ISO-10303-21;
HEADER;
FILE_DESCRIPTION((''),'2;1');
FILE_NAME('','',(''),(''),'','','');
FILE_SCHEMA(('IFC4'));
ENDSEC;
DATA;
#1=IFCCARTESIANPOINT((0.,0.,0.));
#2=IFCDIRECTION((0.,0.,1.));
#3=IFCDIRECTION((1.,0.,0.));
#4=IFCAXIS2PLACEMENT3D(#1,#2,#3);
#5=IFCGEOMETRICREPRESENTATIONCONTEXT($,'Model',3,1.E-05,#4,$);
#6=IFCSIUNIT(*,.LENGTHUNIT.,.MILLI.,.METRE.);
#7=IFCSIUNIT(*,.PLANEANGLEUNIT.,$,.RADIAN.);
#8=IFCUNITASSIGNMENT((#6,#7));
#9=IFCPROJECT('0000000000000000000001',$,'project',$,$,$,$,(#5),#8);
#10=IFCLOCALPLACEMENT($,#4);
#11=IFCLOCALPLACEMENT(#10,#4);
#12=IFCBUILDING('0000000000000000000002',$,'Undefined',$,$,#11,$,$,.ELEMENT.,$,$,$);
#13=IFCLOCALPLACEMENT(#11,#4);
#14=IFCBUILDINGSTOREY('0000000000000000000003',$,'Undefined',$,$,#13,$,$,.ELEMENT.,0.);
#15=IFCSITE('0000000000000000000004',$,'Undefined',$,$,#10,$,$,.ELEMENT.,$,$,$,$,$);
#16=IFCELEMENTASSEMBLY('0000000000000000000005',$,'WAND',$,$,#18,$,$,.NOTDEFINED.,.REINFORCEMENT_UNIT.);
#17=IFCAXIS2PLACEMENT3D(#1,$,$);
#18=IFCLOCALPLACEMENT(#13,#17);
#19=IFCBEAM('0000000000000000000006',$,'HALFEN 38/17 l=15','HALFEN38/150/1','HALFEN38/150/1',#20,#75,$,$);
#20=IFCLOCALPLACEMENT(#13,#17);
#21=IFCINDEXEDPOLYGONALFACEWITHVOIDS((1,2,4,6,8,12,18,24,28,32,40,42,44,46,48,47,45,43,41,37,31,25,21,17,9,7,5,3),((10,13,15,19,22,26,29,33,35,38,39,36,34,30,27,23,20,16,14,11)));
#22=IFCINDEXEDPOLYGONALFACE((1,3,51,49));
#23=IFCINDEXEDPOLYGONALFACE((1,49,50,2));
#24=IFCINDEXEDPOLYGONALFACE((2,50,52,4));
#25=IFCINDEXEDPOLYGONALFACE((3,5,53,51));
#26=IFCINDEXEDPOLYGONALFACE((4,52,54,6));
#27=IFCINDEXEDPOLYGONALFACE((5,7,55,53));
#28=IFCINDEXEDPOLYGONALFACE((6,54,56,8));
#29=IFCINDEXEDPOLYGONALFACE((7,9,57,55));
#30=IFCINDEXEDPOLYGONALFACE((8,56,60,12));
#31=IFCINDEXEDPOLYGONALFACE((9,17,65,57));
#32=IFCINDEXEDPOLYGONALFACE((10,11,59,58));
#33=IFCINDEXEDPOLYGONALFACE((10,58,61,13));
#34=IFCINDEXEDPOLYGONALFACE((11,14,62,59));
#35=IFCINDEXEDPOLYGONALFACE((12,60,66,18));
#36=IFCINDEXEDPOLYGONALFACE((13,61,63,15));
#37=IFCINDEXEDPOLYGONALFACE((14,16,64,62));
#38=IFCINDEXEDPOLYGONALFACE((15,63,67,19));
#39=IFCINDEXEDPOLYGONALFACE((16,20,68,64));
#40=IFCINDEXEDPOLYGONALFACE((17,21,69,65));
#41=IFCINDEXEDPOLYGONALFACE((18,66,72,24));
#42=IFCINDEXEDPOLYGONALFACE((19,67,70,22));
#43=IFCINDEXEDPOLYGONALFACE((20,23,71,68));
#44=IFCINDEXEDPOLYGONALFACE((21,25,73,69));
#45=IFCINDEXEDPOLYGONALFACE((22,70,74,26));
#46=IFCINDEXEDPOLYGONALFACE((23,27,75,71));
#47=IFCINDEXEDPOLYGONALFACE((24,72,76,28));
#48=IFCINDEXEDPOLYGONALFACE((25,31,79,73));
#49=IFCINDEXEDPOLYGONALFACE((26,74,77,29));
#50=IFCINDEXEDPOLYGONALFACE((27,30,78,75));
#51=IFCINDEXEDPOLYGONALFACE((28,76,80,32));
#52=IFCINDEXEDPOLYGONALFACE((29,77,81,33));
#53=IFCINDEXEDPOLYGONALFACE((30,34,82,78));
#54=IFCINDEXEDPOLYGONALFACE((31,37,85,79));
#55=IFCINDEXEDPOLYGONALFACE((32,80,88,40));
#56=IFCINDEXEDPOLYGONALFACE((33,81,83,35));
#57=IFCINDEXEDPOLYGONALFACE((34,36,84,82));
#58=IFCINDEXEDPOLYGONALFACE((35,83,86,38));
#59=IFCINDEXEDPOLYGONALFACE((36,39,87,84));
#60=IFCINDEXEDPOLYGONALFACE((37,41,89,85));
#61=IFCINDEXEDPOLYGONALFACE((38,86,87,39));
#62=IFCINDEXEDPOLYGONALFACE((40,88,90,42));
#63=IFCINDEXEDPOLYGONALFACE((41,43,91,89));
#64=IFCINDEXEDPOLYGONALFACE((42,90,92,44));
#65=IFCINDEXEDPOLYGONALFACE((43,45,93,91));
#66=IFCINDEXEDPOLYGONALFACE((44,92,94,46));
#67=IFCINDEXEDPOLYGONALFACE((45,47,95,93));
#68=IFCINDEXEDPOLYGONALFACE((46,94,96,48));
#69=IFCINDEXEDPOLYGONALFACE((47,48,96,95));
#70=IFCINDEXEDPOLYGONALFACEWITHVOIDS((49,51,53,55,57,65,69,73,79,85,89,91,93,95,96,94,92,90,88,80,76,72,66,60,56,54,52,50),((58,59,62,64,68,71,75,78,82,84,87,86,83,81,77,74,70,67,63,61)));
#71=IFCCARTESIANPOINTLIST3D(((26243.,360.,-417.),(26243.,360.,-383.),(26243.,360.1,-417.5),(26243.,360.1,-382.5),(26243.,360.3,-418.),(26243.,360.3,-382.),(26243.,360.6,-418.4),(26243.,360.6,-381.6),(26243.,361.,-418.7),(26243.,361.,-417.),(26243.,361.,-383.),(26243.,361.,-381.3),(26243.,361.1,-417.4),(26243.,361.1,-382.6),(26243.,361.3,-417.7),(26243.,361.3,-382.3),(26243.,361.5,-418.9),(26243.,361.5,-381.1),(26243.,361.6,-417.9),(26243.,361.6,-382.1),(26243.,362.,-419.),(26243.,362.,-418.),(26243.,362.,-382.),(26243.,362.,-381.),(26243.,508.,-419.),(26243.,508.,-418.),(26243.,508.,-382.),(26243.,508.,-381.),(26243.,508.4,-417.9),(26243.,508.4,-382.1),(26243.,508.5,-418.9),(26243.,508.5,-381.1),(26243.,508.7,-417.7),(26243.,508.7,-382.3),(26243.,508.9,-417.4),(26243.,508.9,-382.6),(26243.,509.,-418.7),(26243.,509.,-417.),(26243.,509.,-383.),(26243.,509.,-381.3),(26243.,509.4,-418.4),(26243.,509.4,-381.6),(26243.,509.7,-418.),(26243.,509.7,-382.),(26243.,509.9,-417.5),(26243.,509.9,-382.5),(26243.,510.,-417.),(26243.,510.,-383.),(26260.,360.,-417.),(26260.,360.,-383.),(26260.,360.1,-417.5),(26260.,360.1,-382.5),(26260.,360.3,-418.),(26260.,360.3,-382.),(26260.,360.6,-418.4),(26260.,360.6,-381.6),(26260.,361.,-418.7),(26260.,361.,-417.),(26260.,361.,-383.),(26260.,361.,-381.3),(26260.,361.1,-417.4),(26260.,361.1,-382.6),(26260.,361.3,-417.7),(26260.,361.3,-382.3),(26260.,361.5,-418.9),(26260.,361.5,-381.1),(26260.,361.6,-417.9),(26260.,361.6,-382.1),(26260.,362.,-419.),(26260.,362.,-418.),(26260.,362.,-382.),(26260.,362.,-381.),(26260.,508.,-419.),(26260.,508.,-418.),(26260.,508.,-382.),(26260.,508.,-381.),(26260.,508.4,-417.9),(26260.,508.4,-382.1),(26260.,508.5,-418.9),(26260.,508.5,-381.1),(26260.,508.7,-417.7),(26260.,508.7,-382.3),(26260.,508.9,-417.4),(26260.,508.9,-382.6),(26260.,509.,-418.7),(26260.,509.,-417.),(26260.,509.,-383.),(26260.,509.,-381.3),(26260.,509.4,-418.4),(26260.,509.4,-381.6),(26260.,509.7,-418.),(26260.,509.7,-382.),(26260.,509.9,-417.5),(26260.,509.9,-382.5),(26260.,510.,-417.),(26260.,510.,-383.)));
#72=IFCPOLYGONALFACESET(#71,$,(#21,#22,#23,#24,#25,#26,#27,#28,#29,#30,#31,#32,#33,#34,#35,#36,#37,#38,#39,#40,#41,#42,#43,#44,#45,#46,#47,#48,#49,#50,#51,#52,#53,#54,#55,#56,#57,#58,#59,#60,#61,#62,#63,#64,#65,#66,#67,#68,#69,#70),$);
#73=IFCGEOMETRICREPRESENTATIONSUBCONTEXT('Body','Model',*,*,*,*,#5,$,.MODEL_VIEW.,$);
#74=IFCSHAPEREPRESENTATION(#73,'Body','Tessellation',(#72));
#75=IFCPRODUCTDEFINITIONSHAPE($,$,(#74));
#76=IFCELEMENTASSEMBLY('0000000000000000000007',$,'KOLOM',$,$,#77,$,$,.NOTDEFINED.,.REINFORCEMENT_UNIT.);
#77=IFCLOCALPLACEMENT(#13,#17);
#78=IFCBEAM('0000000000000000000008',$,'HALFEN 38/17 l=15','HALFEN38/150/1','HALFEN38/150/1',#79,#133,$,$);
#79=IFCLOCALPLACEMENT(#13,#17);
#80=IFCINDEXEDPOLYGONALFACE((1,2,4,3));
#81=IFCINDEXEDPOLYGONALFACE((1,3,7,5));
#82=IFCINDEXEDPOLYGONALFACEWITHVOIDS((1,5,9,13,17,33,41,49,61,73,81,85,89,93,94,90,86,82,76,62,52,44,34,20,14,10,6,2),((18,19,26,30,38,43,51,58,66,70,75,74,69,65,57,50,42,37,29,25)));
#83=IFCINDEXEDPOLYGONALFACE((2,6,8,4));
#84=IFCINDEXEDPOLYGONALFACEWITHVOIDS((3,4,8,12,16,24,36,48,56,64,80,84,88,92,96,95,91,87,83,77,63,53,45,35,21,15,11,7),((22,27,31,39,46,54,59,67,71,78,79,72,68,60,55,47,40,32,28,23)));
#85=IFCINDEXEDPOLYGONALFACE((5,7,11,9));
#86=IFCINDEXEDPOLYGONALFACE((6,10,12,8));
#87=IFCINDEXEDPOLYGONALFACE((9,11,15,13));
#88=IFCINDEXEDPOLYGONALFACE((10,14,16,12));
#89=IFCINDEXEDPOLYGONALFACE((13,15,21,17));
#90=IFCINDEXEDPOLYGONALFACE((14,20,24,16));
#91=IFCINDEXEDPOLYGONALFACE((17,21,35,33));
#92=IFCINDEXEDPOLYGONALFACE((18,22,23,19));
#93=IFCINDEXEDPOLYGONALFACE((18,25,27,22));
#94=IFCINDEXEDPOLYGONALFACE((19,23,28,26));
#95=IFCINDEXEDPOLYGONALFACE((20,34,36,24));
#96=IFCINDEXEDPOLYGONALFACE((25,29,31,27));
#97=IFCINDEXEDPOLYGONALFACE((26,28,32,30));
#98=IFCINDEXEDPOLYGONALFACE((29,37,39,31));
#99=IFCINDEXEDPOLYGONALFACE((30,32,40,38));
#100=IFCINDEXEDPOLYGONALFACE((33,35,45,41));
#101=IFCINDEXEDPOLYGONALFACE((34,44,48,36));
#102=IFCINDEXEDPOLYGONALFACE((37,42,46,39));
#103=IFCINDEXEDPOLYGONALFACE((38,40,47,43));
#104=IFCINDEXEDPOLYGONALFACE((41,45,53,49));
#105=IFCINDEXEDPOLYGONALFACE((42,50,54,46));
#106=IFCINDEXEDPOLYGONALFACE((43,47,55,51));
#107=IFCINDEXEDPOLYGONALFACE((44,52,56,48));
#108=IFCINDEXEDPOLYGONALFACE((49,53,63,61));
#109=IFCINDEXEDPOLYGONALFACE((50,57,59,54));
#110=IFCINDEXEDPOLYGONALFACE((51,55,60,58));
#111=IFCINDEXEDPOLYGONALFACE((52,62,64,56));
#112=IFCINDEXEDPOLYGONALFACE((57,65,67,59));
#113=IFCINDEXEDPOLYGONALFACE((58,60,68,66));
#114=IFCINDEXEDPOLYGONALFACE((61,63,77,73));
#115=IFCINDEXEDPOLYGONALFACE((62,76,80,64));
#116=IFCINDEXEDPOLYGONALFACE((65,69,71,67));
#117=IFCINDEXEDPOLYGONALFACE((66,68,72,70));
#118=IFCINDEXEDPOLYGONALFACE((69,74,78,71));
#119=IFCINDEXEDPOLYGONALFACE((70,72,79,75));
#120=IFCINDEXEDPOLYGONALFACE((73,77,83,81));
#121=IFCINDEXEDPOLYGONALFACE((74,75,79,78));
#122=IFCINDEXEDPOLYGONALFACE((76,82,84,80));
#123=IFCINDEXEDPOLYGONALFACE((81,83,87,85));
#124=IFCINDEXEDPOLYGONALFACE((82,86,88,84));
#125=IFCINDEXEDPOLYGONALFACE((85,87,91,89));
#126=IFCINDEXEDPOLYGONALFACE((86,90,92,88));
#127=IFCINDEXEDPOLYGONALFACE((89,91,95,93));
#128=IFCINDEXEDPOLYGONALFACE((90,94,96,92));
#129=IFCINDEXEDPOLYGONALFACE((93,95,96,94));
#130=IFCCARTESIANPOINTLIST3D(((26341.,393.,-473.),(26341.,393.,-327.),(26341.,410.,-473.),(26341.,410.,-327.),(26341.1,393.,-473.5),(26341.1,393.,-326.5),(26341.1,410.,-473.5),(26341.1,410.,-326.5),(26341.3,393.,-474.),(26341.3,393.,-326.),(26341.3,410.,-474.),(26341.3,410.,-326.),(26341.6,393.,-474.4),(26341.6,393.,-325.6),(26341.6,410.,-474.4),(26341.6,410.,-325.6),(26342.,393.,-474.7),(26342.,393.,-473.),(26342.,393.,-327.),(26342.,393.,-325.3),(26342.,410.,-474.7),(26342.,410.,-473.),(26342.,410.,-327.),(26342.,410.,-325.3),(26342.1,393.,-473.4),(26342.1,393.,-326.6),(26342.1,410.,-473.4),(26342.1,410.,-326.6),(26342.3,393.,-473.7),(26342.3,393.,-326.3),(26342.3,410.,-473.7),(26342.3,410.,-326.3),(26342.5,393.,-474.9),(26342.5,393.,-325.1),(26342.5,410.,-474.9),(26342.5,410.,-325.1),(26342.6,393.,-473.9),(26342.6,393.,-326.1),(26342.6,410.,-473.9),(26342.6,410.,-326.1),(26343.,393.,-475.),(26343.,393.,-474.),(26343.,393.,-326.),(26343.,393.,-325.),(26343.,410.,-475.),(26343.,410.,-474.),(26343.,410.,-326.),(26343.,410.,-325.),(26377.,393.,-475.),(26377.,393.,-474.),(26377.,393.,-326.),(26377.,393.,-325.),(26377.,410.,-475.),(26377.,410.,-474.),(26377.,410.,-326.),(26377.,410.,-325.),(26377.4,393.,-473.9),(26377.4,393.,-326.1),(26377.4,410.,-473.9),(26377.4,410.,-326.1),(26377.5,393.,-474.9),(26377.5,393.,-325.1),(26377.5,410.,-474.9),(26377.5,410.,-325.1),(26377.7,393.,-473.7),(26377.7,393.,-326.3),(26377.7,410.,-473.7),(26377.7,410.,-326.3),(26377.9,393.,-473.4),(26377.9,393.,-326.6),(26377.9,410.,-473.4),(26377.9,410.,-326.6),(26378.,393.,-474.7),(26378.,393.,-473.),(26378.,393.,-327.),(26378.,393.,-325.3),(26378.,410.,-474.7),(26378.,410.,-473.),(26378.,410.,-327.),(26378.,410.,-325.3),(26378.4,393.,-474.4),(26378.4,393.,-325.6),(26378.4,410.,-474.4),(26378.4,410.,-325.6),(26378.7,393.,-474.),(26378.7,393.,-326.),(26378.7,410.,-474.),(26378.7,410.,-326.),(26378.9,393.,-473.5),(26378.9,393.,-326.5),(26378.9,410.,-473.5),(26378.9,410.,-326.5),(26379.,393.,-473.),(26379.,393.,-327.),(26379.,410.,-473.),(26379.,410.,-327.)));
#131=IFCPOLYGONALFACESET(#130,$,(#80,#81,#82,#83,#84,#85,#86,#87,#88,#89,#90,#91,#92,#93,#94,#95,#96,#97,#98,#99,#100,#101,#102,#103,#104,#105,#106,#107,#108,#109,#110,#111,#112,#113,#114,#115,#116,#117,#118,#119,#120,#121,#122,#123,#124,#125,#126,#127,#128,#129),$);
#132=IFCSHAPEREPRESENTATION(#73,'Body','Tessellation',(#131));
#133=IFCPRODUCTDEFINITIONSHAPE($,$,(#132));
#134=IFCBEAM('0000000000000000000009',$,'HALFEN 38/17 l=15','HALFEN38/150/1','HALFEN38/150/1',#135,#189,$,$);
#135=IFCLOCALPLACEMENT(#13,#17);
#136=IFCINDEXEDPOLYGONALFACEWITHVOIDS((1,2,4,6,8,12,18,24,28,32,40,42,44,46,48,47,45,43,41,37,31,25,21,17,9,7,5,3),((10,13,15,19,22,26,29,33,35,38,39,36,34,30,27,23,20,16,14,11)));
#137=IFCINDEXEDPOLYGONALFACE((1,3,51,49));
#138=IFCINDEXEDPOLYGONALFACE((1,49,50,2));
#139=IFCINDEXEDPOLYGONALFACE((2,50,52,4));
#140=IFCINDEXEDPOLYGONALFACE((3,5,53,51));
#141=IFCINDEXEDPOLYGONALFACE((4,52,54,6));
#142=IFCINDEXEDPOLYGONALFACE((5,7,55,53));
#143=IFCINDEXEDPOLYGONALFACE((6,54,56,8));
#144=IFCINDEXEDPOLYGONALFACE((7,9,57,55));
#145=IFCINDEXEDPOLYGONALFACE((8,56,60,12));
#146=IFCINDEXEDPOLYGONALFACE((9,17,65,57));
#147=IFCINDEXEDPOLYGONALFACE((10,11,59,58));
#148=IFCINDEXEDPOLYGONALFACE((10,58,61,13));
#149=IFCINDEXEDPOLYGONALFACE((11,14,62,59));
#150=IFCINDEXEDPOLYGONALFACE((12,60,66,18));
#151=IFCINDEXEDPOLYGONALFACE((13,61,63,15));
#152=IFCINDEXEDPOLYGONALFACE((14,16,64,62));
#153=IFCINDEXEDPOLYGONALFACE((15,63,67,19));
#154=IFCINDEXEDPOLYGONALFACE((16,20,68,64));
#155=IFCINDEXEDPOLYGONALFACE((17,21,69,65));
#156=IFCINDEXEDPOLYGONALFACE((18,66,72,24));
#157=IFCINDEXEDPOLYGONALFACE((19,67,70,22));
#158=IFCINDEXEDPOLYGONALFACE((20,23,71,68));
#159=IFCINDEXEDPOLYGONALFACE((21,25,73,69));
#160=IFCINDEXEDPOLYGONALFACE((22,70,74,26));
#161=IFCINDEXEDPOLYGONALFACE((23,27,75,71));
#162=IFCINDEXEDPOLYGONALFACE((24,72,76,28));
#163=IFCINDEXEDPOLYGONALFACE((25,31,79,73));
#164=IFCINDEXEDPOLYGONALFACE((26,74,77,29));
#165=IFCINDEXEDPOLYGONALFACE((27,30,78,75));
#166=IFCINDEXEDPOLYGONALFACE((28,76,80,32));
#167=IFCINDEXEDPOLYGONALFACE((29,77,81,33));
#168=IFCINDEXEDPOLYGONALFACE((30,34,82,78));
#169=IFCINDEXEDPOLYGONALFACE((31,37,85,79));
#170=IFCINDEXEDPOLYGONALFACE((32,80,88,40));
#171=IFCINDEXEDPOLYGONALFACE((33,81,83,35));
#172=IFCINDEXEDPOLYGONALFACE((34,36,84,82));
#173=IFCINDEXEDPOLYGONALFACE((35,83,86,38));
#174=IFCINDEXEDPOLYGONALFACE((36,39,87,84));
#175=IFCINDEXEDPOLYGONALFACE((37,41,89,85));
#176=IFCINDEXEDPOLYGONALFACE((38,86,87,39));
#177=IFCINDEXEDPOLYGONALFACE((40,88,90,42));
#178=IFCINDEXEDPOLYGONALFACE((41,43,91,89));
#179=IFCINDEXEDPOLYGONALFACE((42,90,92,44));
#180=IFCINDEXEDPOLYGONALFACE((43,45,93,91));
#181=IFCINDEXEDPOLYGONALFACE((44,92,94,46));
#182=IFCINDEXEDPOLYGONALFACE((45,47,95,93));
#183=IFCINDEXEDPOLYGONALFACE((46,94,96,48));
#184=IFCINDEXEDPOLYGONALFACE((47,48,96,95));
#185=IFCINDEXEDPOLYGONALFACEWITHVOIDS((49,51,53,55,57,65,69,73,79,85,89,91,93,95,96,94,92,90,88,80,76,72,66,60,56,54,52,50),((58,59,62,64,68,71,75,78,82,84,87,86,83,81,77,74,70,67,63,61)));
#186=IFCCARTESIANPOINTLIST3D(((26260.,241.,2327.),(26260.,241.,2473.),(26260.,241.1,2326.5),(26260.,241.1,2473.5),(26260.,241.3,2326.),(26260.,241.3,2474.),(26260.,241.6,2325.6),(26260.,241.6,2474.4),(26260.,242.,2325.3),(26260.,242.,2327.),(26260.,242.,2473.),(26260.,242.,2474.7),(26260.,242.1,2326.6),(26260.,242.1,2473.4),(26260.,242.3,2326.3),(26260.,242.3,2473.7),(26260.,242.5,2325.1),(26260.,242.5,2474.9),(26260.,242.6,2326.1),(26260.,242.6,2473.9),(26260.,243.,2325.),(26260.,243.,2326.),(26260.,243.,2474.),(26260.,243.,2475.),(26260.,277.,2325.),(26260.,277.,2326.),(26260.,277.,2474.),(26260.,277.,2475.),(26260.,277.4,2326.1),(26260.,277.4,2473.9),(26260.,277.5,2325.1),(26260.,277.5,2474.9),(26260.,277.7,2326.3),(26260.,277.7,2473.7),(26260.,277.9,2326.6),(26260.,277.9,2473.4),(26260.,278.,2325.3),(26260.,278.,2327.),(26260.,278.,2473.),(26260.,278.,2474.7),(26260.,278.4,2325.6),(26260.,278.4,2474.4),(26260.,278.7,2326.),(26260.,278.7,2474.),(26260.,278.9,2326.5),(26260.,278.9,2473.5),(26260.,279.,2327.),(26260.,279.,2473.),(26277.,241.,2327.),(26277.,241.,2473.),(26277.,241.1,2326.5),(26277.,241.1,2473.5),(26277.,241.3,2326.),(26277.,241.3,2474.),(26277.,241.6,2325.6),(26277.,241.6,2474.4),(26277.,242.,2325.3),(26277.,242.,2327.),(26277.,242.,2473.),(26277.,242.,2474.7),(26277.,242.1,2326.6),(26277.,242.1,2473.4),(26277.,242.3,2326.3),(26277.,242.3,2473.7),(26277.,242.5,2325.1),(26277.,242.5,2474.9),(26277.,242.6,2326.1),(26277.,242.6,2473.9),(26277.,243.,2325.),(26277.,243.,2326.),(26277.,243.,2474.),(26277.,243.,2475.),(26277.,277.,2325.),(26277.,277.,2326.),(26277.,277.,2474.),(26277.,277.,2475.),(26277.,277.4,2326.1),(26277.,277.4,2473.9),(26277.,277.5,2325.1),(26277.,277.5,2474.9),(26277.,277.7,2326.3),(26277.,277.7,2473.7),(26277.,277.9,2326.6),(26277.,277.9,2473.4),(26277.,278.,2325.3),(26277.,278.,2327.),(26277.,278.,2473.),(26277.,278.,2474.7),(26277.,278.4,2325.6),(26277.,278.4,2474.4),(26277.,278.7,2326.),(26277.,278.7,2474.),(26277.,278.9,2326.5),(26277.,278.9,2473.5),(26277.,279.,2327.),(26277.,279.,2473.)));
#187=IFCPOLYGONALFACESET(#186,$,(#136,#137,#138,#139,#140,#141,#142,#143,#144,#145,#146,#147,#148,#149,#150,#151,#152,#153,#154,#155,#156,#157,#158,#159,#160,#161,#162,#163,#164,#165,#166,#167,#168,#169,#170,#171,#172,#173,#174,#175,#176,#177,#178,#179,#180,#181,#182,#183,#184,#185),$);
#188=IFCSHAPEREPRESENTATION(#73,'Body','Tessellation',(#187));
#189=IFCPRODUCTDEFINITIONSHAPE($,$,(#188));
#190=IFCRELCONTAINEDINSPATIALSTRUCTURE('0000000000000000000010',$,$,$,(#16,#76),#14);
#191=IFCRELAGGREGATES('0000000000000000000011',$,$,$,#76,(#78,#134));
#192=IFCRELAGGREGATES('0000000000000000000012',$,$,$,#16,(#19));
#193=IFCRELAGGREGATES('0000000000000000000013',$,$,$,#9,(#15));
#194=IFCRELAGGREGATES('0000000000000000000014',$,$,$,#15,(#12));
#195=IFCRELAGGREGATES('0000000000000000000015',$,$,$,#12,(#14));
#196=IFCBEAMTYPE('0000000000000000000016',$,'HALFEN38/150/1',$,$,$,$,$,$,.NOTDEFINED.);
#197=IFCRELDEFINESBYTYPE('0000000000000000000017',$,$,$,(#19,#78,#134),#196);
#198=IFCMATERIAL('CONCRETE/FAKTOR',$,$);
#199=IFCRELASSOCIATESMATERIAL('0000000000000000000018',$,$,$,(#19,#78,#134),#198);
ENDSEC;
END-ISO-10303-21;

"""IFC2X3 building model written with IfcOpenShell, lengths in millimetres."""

from ifc_helpers import new_model, si_unit, frame, frame_2d, origin_with_axes, place, context, subcontext, project, spatial, hollow_rectangle, extrude, material, type_object, element, aggregate, save


model = new_model("IFC2X3")

# Units and contexts
model_context = context("Model", 3, precision=1e-05, world=origin_with_axes())
body_context = subcontext(model_context, "Body", "Model", "MODEL_VIEW")
ifc_project = project(units=[si_unit("LENGTHUNIT", "METRE", prefix="MILLI"), si_unit("PLANEANGLEUNIT", "RADIAN")], contexts=[model_context])

# Site, building, storey
site_placement = place(None, origin_with_axes())
site = spatial("IfcSite", under=ifc_project, at=site_placement, Name="Undefined", CompositionType="ELEMENT")
building_placement = place(site_placement, origin_with_axes())
building = spatial("IfcBuilding", under=site, at=building_placement, Name="Undefined", CompositionType="ELEMENT")
storey_placement = place(building_placement, origin_with_axes())
storey = spatial("IfcBuildingStorey", under=building, at=storey_placement, Name="Undefined", CompositionType="ELEMENT", Elevation=0.0)

# Shared definitions
ifc_material_1 = material(Name="CONCRETE/FAKTOR")

# Element assembly, beam
assembly_1_placement = place(storey_placement, origin_with_axes())
assembly_1 = element("IfcElementAssembly", 1, at=assembly_1_placement, inside=storey, Name="WAND", AssemblyPlace="NOTDEFINED", PredefinedType="REINFORCEMENT_UNIT")
beam_type_1 = type_object("IfcBeamType", Name="HALFEN38/150/1", PredefinedType="NOTDEFINED")
beam_1_placement = place(assembly_1_placement, frame((26260.0, 435.0, -400.0), z_axis=(0.0, 0.0, 1.0), x_axis=(-1.0, 0.0, 0.0)))
beam_1 = element("IfcBeam", 2, at=beam_1_placement, type_object=beam_type_1, material=ifc_material_1, Name="HALFEN 38/17 l=15", Description="HALFEN38/150/1", ObjectType="HALFEN38/150/1", context=body_context, shape_type="SweptSolid", body=[
    extrude(hollow_rectangle(XDim=150.0, YDim=38.0, WallThickness=1.0, InnerFilletRadius=1.0, OuterFilletRadius=2.0, at=frame_2d((0.0, 0.0), x_axis=(1.0, 0.0))), frame((17.0, 0.0, 0.0), z_axis=(-1.0, 0.0, 0.0), x_axis=(0.0, -1.0, 0.0)), (0.0, 0.0, 1.0), 17.0),
])

# Element assembly, beams
assembly_2_placement = place(storey_placement, origin_with_axes())
assembly_2 = element("IfcElementAssembly", 3, at=assembly_2_placement, inside=storey, Name="KOLOM", AssemblyPlace="NOTDEFINED", PredefinedType="REINFORCEMENT_UNIT")
beam_2_placement = place(assembly_2_placement, frame((26360.0, 410.0, -400.0), z_axis=(1.0, 0.0, 0.0), x_axis=(0.0, -1.0, 0.0)))
beam_2 = element("IfcBeam", 4, at=beam_2_placement, type_object=beam_type_1, material=ifc_material_1, Name="HALFEN 38/17 l=15", Description="HALFEN38/150/1", ObjectType="HALFEN38/150/1", context=body_context, shape_type="SweptSolid", body=[
    extrude(hollow_rectangle(XDim=150.0, YDim=38.0, WallThickness=1.0, InnerFilletRadius=1.0, OuterFilletRadius=2.0, at=frame_2d((0.0, 0.0), x_axis=(1.0, 0.0))), frame((17.0, 0.0, 0.0), z_axis=(-1.0, 0.0, 0.0), x_axis=(0.0, -1.0, 0.0)), (0.0, 0.0, 1.0), 17.0),
])
beam_3_placement = place(assembly_2_placement, frame((26260.0, 260.0, 2400.0), z_axis=(0.0, 1.0, 0.0), x_axis=(1.0, 0.0, 0.0)))
beam_3 = element("IfcBeam", 5, at=beam_3_placement, type_object=beam_type_1, material=ifc_material_1, Name="HALFEN 38/17 l=15", Description="HALFEN38/150/1", ObjectType="HALFEN38/150/1", context=body_context, shape_type="SweptSolid", body=[
    extrude(hollow_rectangle(XDim=150.0, YDim=38.0, WallThickness=1.0, InnerFilletRadius=1.0, OuterFilletRadius=2.0, at=frame_2d((0.0, 0.0), x_axis=(1.0, 0.0))), frame((17.0, 0.0, 0.0), z_axis=(-1.0, 0.0, 0.0), x_axis=(0.0, -1.0, 0.0)), (0.0, 0.0, 1.0), 17.0),
])
aggregate(assembly_2, [beam_2, beam_3])

aggregate(assembly_1, [beam_1])

save(model, "model.ifc")
